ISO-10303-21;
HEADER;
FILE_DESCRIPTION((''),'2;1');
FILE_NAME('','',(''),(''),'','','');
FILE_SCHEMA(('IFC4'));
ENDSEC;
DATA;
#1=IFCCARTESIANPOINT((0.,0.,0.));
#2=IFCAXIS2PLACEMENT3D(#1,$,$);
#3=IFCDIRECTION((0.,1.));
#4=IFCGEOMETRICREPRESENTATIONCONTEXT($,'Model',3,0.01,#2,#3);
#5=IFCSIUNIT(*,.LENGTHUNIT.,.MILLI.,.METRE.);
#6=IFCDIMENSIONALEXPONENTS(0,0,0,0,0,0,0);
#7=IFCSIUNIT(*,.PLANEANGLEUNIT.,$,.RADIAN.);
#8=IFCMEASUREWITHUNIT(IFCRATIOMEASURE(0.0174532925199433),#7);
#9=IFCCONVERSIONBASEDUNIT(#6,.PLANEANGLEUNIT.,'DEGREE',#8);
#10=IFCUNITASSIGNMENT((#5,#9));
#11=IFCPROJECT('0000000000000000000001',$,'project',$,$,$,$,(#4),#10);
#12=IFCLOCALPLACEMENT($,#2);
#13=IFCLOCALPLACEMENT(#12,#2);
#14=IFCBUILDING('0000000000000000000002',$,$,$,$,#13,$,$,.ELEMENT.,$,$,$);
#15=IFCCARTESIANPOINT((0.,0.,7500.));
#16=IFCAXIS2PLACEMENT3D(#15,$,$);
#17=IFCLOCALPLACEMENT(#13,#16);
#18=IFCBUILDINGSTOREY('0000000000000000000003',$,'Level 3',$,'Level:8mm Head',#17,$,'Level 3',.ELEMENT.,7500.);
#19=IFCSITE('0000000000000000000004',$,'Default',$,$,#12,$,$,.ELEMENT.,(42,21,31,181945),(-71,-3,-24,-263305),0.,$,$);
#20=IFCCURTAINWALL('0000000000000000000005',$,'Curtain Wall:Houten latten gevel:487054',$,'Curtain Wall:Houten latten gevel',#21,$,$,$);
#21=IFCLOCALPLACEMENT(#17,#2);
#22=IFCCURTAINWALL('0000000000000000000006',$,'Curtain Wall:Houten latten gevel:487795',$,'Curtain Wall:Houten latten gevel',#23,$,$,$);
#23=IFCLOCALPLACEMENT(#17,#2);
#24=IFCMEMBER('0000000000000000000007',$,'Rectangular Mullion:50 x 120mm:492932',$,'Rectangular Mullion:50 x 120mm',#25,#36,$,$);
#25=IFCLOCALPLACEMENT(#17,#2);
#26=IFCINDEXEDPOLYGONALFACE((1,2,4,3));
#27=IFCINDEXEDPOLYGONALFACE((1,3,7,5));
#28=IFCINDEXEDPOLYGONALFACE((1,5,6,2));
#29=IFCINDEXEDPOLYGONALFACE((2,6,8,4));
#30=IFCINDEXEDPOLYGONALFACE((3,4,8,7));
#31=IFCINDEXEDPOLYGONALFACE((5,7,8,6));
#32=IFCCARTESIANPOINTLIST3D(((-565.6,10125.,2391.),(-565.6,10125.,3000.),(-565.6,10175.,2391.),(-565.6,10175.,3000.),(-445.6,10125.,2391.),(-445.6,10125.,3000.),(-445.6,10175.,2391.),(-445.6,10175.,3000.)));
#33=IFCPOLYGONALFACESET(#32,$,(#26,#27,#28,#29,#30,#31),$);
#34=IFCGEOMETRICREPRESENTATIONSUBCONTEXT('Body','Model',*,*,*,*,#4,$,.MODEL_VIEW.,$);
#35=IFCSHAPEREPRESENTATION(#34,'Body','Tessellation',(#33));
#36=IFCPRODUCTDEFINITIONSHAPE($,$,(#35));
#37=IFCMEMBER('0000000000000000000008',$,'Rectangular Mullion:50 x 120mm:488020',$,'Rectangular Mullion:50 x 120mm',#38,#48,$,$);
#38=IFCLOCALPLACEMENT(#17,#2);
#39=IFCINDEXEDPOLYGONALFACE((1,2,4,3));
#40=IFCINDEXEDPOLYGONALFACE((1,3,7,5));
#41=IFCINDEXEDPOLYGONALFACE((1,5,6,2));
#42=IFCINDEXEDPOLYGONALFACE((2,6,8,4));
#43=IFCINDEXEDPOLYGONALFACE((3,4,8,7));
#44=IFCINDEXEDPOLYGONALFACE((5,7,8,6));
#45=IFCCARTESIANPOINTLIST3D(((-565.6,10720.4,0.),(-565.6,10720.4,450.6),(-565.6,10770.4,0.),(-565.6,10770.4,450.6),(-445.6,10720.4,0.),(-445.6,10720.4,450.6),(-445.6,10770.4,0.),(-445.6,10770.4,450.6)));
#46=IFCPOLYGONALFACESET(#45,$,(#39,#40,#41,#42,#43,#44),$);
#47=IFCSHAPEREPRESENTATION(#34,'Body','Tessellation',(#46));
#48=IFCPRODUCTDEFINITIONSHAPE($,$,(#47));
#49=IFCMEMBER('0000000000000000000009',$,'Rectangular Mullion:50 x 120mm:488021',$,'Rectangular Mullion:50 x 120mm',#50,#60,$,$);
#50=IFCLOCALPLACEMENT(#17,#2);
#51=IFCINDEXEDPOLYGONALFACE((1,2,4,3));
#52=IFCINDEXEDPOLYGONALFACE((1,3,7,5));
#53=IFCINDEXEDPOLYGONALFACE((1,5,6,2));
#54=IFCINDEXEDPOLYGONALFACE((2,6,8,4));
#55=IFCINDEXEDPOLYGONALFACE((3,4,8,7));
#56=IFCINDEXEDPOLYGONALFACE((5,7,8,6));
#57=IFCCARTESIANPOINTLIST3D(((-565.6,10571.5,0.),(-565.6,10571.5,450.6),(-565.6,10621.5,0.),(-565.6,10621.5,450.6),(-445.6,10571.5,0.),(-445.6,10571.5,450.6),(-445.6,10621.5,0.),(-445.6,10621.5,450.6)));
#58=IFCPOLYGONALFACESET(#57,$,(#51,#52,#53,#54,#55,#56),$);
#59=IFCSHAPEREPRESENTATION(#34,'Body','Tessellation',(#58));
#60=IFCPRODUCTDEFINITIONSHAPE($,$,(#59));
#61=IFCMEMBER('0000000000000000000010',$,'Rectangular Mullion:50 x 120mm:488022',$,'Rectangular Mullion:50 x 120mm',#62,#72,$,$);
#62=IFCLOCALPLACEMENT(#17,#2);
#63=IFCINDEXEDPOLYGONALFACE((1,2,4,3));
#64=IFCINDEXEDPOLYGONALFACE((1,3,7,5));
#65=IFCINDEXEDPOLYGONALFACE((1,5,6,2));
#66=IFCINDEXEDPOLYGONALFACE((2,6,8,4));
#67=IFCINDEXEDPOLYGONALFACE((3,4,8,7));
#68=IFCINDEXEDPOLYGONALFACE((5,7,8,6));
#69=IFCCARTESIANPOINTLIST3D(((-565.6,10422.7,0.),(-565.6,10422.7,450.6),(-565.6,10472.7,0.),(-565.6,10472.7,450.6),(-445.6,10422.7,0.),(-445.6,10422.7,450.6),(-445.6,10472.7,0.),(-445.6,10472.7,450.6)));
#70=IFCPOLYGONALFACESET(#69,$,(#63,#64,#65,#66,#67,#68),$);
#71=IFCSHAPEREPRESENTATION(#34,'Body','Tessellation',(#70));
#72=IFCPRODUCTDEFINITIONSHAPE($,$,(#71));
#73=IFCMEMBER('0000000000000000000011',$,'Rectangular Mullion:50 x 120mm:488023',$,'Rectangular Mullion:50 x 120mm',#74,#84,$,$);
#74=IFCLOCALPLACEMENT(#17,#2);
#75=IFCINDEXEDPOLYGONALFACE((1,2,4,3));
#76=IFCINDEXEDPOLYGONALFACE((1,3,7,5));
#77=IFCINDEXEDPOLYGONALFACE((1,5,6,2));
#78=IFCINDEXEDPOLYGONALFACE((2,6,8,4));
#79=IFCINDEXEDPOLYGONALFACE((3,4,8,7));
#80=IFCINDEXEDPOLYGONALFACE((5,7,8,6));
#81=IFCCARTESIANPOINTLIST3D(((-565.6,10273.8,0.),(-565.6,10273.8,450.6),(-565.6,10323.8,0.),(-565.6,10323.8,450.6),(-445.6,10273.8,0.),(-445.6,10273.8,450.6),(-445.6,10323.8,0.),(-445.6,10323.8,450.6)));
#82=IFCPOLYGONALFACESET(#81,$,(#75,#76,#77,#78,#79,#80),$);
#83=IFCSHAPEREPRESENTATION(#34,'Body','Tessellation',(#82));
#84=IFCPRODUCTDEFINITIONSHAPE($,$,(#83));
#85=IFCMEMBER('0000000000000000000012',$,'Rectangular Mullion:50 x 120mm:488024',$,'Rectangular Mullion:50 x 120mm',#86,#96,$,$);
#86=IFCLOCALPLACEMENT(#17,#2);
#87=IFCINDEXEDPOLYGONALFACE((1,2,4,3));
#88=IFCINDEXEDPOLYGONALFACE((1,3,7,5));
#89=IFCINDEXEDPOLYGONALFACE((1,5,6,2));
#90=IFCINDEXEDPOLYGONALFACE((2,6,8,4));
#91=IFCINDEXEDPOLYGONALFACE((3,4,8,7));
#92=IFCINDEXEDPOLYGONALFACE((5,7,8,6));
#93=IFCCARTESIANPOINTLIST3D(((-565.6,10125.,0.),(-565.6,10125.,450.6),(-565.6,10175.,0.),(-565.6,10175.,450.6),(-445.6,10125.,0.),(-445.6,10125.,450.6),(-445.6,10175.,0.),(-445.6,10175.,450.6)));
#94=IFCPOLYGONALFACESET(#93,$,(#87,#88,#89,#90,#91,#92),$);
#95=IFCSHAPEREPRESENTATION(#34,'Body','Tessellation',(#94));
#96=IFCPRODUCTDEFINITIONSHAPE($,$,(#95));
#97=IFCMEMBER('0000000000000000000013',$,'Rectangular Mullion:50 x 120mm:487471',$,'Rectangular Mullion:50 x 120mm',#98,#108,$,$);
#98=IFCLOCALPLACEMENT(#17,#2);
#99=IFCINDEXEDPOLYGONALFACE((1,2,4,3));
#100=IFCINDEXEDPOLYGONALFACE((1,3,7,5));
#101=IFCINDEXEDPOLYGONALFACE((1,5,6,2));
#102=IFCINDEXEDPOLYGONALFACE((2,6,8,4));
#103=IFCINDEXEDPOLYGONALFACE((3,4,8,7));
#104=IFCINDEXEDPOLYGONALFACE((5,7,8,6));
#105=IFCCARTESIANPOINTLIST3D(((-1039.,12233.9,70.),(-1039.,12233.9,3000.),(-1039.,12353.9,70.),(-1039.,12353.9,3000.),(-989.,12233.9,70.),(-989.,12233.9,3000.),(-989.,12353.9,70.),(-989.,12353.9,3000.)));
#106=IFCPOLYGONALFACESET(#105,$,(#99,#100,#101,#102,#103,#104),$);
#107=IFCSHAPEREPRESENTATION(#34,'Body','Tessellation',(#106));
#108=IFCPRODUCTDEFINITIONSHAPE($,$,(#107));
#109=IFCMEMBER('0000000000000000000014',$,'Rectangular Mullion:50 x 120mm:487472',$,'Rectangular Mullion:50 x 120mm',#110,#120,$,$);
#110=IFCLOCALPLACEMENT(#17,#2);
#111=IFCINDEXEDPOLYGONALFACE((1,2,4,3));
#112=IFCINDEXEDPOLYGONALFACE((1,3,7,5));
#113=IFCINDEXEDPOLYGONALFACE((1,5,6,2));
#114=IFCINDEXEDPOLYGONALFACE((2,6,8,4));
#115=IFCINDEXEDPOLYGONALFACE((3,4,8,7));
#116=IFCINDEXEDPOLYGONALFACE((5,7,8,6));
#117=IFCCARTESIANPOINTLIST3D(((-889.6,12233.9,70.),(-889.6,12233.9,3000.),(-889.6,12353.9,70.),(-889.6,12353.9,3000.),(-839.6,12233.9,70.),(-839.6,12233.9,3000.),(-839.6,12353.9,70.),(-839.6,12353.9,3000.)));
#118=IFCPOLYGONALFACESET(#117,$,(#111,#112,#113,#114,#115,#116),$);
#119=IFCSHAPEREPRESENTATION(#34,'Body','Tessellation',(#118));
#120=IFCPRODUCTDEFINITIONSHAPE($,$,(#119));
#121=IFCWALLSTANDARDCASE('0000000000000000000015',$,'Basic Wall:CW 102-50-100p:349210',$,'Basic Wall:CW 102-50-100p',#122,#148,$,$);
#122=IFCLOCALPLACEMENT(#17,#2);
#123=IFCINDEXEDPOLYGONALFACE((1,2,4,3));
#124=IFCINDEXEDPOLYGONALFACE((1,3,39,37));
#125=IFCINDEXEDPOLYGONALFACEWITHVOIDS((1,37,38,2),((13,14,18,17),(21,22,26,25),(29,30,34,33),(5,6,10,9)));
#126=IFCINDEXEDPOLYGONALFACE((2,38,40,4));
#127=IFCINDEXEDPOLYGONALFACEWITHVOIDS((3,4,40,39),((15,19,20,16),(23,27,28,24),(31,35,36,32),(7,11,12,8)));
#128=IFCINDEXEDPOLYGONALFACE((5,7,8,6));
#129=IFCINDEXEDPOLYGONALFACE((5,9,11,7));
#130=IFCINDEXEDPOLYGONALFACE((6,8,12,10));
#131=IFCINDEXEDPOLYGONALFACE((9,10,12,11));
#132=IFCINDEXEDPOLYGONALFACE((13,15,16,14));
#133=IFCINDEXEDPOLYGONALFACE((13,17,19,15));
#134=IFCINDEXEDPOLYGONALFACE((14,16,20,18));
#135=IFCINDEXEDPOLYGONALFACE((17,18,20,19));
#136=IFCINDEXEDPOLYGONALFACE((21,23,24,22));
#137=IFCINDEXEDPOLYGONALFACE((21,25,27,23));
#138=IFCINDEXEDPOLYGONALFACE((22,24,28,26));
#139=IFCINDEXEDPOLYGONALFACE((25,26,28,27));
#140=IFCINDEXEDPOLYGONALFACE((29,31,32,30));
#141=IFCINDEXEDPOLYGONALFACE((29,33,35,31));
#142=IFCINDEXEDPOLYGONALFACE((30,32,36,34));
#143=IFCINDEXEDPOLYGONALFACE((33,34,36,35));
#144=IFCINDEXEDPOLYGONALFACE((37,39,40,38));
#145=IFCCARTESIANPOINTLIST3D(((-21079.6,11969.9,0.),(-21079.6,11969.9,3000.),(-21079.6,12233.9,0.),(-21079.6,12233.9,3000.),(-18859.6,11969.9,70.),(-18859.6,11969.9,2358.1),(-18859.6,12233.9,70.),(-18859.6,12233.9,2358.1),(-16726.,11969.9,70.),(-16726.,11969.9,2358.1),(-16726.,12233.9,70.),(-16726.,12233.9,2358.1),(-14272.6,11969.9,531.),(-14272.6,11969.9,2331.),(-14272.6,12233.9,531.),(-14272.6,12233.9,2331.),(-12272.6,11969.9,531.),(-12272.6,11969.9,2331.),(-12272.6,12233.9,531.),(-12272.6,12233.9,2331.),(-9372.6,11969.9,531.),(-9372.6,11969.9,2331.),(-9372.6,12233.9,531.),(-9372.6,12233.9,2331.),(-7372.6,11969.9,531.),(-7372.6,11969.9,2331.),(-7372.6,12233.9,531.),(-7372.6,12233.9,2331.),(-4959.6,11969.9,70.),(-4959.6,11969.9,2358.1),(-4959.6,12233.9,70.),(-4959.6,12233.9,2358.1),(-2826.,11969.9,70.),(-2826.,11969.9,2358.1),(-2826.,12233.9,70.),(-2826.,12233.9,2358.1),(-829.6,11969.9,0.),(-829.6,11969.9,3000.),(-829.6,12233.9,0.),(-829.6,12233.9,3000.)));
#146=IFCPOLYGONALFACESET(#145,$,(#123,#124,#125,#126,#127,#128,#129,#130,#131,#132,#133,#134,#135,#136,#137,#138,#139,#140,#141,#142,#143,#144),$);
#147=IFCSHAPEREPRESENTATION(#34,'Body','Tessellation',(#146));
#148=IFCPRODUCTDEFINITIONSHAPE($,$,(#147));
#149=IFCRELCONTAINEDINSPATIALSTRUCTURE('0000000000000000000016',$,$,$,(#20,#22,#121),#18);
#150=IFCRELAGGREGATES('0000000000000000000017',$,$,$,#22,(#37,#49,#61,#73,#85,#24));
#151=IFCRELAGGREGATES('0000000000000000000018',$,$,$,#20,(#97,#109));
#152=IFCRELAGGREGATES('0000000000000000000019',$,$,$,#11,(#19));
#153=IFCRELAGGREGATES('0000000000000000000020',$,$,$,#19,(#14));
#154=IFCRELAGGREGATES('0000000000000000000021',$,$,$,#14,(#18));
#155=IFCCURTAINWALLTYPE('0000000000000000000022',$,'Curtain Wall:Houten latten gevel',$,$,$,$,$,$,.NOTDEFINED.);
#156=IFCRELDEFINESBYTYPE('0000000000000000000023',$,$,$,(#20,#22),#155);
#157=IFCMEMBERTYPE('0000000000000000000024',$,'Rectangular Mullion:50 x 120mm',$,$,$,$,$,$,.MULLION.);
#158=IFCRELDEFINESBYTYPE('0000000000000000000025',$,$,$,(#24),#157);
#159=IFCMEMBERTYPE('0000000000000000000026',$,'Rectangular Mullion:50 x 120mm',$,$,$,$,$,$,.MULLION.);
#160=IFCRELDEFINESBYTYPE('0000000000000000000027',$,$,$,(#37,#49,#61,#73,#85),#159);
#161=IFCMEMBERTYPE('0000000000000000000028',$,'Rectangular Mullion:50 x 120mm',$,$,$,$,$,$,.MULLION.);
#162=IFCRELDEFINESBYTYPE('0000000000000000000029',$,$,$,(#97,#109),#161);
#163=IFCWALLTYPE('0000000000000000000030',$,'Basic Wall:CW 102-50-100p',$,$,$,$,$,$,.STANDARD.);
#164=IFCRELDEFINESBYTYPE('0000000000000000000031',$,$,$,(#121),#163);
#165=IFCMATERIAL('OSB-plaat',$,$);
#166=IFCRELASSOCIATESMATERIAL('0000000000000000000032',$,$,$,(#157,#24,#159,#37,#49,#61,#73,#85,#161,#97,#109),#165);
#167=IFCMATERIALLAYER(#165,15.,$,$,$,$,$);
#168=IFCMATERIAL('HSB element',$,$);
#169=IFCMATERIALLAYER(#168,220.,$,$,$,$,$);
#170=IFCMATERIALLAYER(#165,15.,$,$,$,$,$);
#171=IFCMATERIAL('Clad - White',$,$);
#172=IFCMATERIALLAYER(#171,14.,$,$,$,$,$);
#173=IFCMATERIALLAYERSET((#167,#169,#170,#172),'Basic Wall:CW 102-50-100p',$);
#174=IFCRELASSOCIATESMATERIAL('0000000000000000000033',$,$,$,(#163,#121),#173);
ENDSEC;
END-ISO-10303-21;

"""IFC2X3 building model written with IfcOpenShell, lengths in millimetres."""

from ifc_helpers import new_model, entity, si_unit, converted_unit, direction, frame, frame_2d, origin, origin_2d_with_axis, place, context, subcontext, project, spatial, rectangle, extrude, source, transform, mapped, material, layer, layer_set, layer_usage, type_object, type_shapes, element, aggregate, save


model = new_model("IFC2X3")

# Units and contexts
model_context = context("Model", 3, precision=0.01, world=origin(), true_north=direction((0.0, 1.0)))
body_context = subcontext(model_context, "Body", "Model", "MODEL_VIEW")
ifc_project = project(units=[si_unit("LENGTHUNIT", "METRE", prefix="MILLI"), converted_unit("PLANEANGLEUNIT", "DEGREE", entity("IfcRatioMeasure", 0.0174532925199433), si_unit("PLANEANGLEUNIT", "RADIAN"), dimensions=[0, 0, 0, 0, 0, 0, 0])], contexts=[model_context])

# Site, building, storey
site_placement = place(None, frame((0.0, 0.0, 0.0)))
site = spatial("IfcSite", under=ifc_project, at=site_placement, Name="Default", CompositionType="ELEMENT", RefLatitude=(42, 21, 31, 181945), RefLongitude=(-71, -3, -24, -263305), RefElevation=0.0)
building_placement = place(site_placement, origin())
building = spatial("IfcBuilding", under=site, at=building_placement, CompositionType="ELEMENT")
storey_placement = place(building_placement, frame((0.0, 0.0, 7500.0)))
storey = spatial("IfcBuildingStorey", under=building, at=storey_placement, Name="Level 3", ObjectType="Level:8mm Head", LongName="Level 3", CompositionType="ELEMENT", Elevation=7500.0)

# Curtain wall
curtain_wall_type = type_object("IfcCurtainWallType", Name="Curtain Wall:Houten latten gevel", PredefinedType="NOTDEFINED")
curtain_wall_1_placement = place(storey_placement, frame((0.0, 0.0, -7500.0)))
curtain_wall_1 = element("IfcCurtainWall", 1, at=curtain_wall_1_placement, inside=storey, type_object=curtain_wall_type, Name="Curtain Wall:Houten latten gevel:487054", ObjectType="Curtain Wall:Houten latten gevel")
ifc_material_1 = material(Name="OSB-plaat")

# Curtain wall, members
curtain_wall_2_placement = place(storey_placement, frame((0.0, 0.0, -7500.0)))
curtain_wall_2 = element("IfcCurtainWall", 2, at=curtain_wall_2_placement, inside=storey, type_object=curtain_wall_type, Name="Curtain Wall:Houten latten gevel:487795", ObjectType="Curtain Wall:Houten latten gevel")
member_type_1 = type_object("IfcMemberType", Name="Rectangular Mullion:50 x 120mm", PredefinedType="MULLION", material=ifc_material_1)
shared_shape_1 = source(origin(), body_context, "Body", "SweptSolid", [
    extrude(rectangle(XDim=120.0, YDim=50.0, at=origin_2d_with_axis()), frame((0.0, 0.0, -609.0), z_axis=(0.0, 0.0, 1.0), x_axis=(0.0, -1.0, 0.0)), (0.0, 0.0, 1.0), 609.0),
])
type_shapes(member_type_1, [shared_shape_1])
member_1_placement = place(storey_placement, frame((-505.6, 10150.0, 2391.0), z_axis=(0.0, 0.0, -1.0), x_axis=(0.0, -1.0, 0.0)))
member_1 = element("IfcMember", 3, at=member_1_placement, type_object=member_type_1, material=ifc_material_1, Name="Rectangular Mullion:50 x 120mm:492932", ObjectType="Rectangular Mullion:50 x 120mm", context=body_context, shape_type="MappedRepresentation", body=[
    mapped(shared_shape_1, transform((0.0, 0.0, 0.0), scale=1.0)),
])
member_type_2 = type_object("IfcMemberType", Name="Rectangular Mullion:50 x 120mm", PredefinedType="MULLION", material=ifc_material_1)
shared_shape_2 = source(origin(), body_context, "Body", "SweptSolid", [
    extrude(rectangle(XDim=120.0, YDim=50.0, at=origin_2d_with_axis()), frame((0.0, 0.0, -450.6), z_axis=(0.0, 0.0, 1.0), x_axis=(0.0, -1.0, 0.0)), (0.0, 0.0, 1.0), 450.6),
])
type_shapes(member_type_2, [shared_shape_2])
member_2_placement = place(storey_placement, frame((-505.6, 10745.4, 0.0), z_axis=(0.0, 0.0, -1.0), x_axis=(0.0, -1.0, 0.0)))
member_2 = element("IfcMember", 4, at=member_2_placement, type_object=member_type_2, material=ifc_material_1, Name="Rectangular Mullion:50 x 120mm:488020", ObjectType="Rectangular Mullion:50 x 120mm", context=body_context, shape_type="MappedRepresentation", body=[
    mapped(shared_shape_2, transform((0.0, 0.0, 0.0), scale=1.0)),
])
member_3_placement = place(storey_placement, frame((-505.6, 10596.5, 0.0), z_axis=(0.0, 0.0, -1.0), x_axis=(0.0, -1.0, 0.0)))
member_3 = element("IfcMember", 5, at=member_3_placement, type_object=member_type_2, material=ifc_material_1, Name="Rectangular Mullion:50 x 120mm:488021", ObjectType="Rectangular Mullion:50 x 120mm", context=body_context, shape_type="MappedRepresentation", body=[
    mapped(shared_shape_2, transform((0.0, 0.0, 0.0), scale=1.0)),
])
member_4_placement = place(storey_placement, frame((-505.6, 10447.7, 0.0), z_axis=(0.0, 0.0, -1.0), x_axis=(0.0, -1.0, 0.0)))
member_4 = element("IfcMember", 6, at=member_4_placement, type_object=member_type_2, material=ifc_material_1, Name="Rectangular Mullion:50 x 120mm:488022", ObjectType="Rectangular Mullion:50 x 120mm", context=body_context, shape_type="MappedRepresentation", body=[
    mapped(shared_shape_2, transform((0.0, 0.0, 0.0), scale=1.0)),
])
member_5_placement = place(storey_placement, frame((-505.6, 10298.8, 0.0), z_axis=(0.0, 0.0, -1.0), x_axis=(0.0, -1.0, 0.0)))
member_5 = element("IfcMember", 7, at=member_5_placement, type_object=member_type_2, material=ifc_material_1, Name="Rectangular Mullion:50 x 120mm:488023", ObjectType="Rectangular Mullion:50 x 120mm", context=body_context, shape_type="MappedRepresentation", body=[
    mapped(shared_shape_2, transform((0.0, 0.0, 0.0), scale=1.0)),
])
member_6_placement = place(storey_placement, frame((-505.6, 10150.0, 0.0), z_axis=(0.0, 0.0, -1.0), x_axis=(0.0, -1.0, 0.0)))
member_6 = element("IfcMember", 8, at=member_6_placement, type_object=member_type_2, material=ifc_material_1, Name="Rectangular Mullion:50 x 120mm:488024", ObjectType="Rectangular Mullion:50 x 120mm", context=body_context, shape_type="MappedRepresentation", body=[
    mapped(shared_shape_2, transform((0.0, 0.0, 0.0), scale=1.0)),
])
aggregate(curtain_wall_2, [member_2, member_3, member_4, member_5, member_6, member_1])

# Members
member_type_3 = type_object("IfcMemberType", Name="Rectangular Mullion:50 x 120mm", PredefinedType="MULLION", material=ifc_material_1)
shared_shape_3 = source(origin(), body_context, "Body", "SweptSolid", [
    extrude(rectangle(XDim=120.0, YDim=50.0, at=origin_2d_with_axis()), frame((0.0, 0.0, -2930.0), z_axis=(0.0, 0.0, 1.0), x_axis=(0.0, -1.0, 0.0)), (0.0, 0.0, 1.0), 2930.0),
])
type_shapes(member_type_3, [shared_shape_3])
member_7_placement = place(storey_placement, frame((-1014.0, 12293.9, 70.0), z_axis=(0.0, 0.0, -1.0), x_axis=(1.0, 0.0, 0.0)))
member_7 = element("IfcMember", 9, at=member_7_placement, type_object=member_type_3, material=ifc_material_1, Name="Rectangular Mullion:50 x 120mm:487471", ObjectType="Rectangular Mullion:50 x 120mm", context=body_context, shape_type="MappedRepresentation", body=[
    mapped(shared_shape_3, transform((0.0, 0.0, 0.0), scale=1.0)),
])
member_8_placement = place(storey_placement, frame((-864.6, 12293.9, 70.0), z_axis=(0.0, 0.0, -1.0), x_axis=(1.0, 0.0, 0.0)))
member_8 = element("IfcMember", 10, at=member_8_placement, type_object=member_type_3, material=ifc_material_1, Name="Rectangular Mullion:50 x 120mm:487472", ObjectType="Rectangular Mullion:50 x 120mm", context=body_context, shape_type="MappedRepresentation", body=[
    mapped(shared_shape_3, transform((0.0, 0.0, 0.0), scale=1.0)),
])
aggregate(curtain_wall_1, [member_7, member_8])

# Wall, openings
ifc_layer_1 = layer(ifc_material_1, 15.0)
ifc_material_2 = material(Name="HSB element")
ifc_layer_2 = layer(ifc_material_2, 220.0)
ifc_layer_3 = layer(ifc_material_1, 15.0)
ifc_material_3 = material(Name="Clad - White")
ifc_layer_4 = layer(ifc_material_3, 14.0)
ifc_layer_set = layer_set([ifc_layer_1, ifc_layer_2, ifc_layer_3, ifc_layer_4], Name="Basic Wall:CW 102-50-100p")
ifc_layer_usage = layer_usage(ifc_layer_set, "AXIS2", "POSITIVE", -132.0)
wall_type = type_object("IfcWallType", Name="Basic Wall:CW 102-50-100p", PredefinedType="STANDARD", material=ifc_layer_set)
wall_placement = place(storey_placement, frame((-829.6, 12101.9, 0.0), z_axis=(0.0, 0.0, 1.0), x_axis=(-1.0, 0.0, 0.0)))
wall = element("IfcWallStandardCase", 11, at=wall_placement, inside=storey, type_object=wall_type, material=ifc_layer_usage, Name="Basic Wall:CW 102-50-100p:349210", ObjectType="Basic Wall:CW 102-50-100p", context=body_context, shape_type="SweptSolid", body=[
    extrude(rectangle(XDim=20250.0, YDim=264.0, at=frame_2d((10125.0, 0.0), x_axis=(-1.0, 0.0))), origin(), (0.0, 0.0, 1.0), 3000.0),
])
opening_1_placement = place(wall_placement, frame((15896.4, -132.0, 70.0)))
element("IfcOpeningElement", 12, at=opening_1_placement, cuts=wall, ObjectType="Opening", context=body_context, shape_type="SweptSolid", body=[
    extrude(rectangle(XDim=2288.1, YDim=2133.6, at=frame_2d((1144.0, 1066.8), x_axis=(1.0, 0.0))), frame((0.0, 0.0, 0.0), z_axis=(0.0, 1.0, 0.0), x_axis=(0.0, 0.0, 1.0)), (0.0, 0.0, 1.0), 264.0),
])
opening_2_placement = place(wall_placement, frame((13443.0, 132.0, 531.0)))
element("IfcOpeningElement", 13, at=opening_2_placement, cuts=wall, ObjectType="Opening", context=body_context, shape_type="SweptSolid", body=[
    extrude(rectangle(XDim=1800.0, YDim=2000.0, at=frame_2d((900.0, 1000.0), x_axis=(-1.0, 0.0))), frame((0.0, 0.0, 0.0), z_axis=(0.0, -1.0, 0.0), x_axis=(0.0, 0.0, 1.0)), (0.0, 0.0, 1.0), 264.0),
])
opening_3_placement = place(wall_placement, frame((8543.0, 132.0, 531.0)))
element("IfcOpeningElement", 14, at=opening_3_placement, cuts=wall, ObjectType="Opening", context=body_context, shape_type="SweptSolid", body=[
    extrude(rectangle(XDim=1800.0, YDim=2000.0, at=frame_2d((900.0, 1000.0), x_axis=(-1.0, 0.0))), frame((0.0, 0.0, 0.0), z_axis=(0.0, -1.0, 0.0), x_axis=(0.0, 0.0, 1.0)), (0.0, 0.0, 1.0), 264.0),
])
opening_4_placement = place(wall_placement, frame((1996.4, -132.0, 70.0)))
element("IfcOpeningElement", 15, at=opening_4_placement, cuts=wall, ObjectType="Opening", context=body_context, shape_type="SweptSolid", body=[
    extrude(rectangle(XDim=2288.1, YDim=2133.6, at=frame_2d((1144.0, 1066.8), x_axis=(1.0, 0.0))), frame((0.0, 0.0, 0.0), z_axis=(0.0, 1.0, 0.0), x_axis=(0.0, 0.0, 1.0)), (0.0, 0.0, 1.0), 264.0),
])

save(model, "model.ifc")
